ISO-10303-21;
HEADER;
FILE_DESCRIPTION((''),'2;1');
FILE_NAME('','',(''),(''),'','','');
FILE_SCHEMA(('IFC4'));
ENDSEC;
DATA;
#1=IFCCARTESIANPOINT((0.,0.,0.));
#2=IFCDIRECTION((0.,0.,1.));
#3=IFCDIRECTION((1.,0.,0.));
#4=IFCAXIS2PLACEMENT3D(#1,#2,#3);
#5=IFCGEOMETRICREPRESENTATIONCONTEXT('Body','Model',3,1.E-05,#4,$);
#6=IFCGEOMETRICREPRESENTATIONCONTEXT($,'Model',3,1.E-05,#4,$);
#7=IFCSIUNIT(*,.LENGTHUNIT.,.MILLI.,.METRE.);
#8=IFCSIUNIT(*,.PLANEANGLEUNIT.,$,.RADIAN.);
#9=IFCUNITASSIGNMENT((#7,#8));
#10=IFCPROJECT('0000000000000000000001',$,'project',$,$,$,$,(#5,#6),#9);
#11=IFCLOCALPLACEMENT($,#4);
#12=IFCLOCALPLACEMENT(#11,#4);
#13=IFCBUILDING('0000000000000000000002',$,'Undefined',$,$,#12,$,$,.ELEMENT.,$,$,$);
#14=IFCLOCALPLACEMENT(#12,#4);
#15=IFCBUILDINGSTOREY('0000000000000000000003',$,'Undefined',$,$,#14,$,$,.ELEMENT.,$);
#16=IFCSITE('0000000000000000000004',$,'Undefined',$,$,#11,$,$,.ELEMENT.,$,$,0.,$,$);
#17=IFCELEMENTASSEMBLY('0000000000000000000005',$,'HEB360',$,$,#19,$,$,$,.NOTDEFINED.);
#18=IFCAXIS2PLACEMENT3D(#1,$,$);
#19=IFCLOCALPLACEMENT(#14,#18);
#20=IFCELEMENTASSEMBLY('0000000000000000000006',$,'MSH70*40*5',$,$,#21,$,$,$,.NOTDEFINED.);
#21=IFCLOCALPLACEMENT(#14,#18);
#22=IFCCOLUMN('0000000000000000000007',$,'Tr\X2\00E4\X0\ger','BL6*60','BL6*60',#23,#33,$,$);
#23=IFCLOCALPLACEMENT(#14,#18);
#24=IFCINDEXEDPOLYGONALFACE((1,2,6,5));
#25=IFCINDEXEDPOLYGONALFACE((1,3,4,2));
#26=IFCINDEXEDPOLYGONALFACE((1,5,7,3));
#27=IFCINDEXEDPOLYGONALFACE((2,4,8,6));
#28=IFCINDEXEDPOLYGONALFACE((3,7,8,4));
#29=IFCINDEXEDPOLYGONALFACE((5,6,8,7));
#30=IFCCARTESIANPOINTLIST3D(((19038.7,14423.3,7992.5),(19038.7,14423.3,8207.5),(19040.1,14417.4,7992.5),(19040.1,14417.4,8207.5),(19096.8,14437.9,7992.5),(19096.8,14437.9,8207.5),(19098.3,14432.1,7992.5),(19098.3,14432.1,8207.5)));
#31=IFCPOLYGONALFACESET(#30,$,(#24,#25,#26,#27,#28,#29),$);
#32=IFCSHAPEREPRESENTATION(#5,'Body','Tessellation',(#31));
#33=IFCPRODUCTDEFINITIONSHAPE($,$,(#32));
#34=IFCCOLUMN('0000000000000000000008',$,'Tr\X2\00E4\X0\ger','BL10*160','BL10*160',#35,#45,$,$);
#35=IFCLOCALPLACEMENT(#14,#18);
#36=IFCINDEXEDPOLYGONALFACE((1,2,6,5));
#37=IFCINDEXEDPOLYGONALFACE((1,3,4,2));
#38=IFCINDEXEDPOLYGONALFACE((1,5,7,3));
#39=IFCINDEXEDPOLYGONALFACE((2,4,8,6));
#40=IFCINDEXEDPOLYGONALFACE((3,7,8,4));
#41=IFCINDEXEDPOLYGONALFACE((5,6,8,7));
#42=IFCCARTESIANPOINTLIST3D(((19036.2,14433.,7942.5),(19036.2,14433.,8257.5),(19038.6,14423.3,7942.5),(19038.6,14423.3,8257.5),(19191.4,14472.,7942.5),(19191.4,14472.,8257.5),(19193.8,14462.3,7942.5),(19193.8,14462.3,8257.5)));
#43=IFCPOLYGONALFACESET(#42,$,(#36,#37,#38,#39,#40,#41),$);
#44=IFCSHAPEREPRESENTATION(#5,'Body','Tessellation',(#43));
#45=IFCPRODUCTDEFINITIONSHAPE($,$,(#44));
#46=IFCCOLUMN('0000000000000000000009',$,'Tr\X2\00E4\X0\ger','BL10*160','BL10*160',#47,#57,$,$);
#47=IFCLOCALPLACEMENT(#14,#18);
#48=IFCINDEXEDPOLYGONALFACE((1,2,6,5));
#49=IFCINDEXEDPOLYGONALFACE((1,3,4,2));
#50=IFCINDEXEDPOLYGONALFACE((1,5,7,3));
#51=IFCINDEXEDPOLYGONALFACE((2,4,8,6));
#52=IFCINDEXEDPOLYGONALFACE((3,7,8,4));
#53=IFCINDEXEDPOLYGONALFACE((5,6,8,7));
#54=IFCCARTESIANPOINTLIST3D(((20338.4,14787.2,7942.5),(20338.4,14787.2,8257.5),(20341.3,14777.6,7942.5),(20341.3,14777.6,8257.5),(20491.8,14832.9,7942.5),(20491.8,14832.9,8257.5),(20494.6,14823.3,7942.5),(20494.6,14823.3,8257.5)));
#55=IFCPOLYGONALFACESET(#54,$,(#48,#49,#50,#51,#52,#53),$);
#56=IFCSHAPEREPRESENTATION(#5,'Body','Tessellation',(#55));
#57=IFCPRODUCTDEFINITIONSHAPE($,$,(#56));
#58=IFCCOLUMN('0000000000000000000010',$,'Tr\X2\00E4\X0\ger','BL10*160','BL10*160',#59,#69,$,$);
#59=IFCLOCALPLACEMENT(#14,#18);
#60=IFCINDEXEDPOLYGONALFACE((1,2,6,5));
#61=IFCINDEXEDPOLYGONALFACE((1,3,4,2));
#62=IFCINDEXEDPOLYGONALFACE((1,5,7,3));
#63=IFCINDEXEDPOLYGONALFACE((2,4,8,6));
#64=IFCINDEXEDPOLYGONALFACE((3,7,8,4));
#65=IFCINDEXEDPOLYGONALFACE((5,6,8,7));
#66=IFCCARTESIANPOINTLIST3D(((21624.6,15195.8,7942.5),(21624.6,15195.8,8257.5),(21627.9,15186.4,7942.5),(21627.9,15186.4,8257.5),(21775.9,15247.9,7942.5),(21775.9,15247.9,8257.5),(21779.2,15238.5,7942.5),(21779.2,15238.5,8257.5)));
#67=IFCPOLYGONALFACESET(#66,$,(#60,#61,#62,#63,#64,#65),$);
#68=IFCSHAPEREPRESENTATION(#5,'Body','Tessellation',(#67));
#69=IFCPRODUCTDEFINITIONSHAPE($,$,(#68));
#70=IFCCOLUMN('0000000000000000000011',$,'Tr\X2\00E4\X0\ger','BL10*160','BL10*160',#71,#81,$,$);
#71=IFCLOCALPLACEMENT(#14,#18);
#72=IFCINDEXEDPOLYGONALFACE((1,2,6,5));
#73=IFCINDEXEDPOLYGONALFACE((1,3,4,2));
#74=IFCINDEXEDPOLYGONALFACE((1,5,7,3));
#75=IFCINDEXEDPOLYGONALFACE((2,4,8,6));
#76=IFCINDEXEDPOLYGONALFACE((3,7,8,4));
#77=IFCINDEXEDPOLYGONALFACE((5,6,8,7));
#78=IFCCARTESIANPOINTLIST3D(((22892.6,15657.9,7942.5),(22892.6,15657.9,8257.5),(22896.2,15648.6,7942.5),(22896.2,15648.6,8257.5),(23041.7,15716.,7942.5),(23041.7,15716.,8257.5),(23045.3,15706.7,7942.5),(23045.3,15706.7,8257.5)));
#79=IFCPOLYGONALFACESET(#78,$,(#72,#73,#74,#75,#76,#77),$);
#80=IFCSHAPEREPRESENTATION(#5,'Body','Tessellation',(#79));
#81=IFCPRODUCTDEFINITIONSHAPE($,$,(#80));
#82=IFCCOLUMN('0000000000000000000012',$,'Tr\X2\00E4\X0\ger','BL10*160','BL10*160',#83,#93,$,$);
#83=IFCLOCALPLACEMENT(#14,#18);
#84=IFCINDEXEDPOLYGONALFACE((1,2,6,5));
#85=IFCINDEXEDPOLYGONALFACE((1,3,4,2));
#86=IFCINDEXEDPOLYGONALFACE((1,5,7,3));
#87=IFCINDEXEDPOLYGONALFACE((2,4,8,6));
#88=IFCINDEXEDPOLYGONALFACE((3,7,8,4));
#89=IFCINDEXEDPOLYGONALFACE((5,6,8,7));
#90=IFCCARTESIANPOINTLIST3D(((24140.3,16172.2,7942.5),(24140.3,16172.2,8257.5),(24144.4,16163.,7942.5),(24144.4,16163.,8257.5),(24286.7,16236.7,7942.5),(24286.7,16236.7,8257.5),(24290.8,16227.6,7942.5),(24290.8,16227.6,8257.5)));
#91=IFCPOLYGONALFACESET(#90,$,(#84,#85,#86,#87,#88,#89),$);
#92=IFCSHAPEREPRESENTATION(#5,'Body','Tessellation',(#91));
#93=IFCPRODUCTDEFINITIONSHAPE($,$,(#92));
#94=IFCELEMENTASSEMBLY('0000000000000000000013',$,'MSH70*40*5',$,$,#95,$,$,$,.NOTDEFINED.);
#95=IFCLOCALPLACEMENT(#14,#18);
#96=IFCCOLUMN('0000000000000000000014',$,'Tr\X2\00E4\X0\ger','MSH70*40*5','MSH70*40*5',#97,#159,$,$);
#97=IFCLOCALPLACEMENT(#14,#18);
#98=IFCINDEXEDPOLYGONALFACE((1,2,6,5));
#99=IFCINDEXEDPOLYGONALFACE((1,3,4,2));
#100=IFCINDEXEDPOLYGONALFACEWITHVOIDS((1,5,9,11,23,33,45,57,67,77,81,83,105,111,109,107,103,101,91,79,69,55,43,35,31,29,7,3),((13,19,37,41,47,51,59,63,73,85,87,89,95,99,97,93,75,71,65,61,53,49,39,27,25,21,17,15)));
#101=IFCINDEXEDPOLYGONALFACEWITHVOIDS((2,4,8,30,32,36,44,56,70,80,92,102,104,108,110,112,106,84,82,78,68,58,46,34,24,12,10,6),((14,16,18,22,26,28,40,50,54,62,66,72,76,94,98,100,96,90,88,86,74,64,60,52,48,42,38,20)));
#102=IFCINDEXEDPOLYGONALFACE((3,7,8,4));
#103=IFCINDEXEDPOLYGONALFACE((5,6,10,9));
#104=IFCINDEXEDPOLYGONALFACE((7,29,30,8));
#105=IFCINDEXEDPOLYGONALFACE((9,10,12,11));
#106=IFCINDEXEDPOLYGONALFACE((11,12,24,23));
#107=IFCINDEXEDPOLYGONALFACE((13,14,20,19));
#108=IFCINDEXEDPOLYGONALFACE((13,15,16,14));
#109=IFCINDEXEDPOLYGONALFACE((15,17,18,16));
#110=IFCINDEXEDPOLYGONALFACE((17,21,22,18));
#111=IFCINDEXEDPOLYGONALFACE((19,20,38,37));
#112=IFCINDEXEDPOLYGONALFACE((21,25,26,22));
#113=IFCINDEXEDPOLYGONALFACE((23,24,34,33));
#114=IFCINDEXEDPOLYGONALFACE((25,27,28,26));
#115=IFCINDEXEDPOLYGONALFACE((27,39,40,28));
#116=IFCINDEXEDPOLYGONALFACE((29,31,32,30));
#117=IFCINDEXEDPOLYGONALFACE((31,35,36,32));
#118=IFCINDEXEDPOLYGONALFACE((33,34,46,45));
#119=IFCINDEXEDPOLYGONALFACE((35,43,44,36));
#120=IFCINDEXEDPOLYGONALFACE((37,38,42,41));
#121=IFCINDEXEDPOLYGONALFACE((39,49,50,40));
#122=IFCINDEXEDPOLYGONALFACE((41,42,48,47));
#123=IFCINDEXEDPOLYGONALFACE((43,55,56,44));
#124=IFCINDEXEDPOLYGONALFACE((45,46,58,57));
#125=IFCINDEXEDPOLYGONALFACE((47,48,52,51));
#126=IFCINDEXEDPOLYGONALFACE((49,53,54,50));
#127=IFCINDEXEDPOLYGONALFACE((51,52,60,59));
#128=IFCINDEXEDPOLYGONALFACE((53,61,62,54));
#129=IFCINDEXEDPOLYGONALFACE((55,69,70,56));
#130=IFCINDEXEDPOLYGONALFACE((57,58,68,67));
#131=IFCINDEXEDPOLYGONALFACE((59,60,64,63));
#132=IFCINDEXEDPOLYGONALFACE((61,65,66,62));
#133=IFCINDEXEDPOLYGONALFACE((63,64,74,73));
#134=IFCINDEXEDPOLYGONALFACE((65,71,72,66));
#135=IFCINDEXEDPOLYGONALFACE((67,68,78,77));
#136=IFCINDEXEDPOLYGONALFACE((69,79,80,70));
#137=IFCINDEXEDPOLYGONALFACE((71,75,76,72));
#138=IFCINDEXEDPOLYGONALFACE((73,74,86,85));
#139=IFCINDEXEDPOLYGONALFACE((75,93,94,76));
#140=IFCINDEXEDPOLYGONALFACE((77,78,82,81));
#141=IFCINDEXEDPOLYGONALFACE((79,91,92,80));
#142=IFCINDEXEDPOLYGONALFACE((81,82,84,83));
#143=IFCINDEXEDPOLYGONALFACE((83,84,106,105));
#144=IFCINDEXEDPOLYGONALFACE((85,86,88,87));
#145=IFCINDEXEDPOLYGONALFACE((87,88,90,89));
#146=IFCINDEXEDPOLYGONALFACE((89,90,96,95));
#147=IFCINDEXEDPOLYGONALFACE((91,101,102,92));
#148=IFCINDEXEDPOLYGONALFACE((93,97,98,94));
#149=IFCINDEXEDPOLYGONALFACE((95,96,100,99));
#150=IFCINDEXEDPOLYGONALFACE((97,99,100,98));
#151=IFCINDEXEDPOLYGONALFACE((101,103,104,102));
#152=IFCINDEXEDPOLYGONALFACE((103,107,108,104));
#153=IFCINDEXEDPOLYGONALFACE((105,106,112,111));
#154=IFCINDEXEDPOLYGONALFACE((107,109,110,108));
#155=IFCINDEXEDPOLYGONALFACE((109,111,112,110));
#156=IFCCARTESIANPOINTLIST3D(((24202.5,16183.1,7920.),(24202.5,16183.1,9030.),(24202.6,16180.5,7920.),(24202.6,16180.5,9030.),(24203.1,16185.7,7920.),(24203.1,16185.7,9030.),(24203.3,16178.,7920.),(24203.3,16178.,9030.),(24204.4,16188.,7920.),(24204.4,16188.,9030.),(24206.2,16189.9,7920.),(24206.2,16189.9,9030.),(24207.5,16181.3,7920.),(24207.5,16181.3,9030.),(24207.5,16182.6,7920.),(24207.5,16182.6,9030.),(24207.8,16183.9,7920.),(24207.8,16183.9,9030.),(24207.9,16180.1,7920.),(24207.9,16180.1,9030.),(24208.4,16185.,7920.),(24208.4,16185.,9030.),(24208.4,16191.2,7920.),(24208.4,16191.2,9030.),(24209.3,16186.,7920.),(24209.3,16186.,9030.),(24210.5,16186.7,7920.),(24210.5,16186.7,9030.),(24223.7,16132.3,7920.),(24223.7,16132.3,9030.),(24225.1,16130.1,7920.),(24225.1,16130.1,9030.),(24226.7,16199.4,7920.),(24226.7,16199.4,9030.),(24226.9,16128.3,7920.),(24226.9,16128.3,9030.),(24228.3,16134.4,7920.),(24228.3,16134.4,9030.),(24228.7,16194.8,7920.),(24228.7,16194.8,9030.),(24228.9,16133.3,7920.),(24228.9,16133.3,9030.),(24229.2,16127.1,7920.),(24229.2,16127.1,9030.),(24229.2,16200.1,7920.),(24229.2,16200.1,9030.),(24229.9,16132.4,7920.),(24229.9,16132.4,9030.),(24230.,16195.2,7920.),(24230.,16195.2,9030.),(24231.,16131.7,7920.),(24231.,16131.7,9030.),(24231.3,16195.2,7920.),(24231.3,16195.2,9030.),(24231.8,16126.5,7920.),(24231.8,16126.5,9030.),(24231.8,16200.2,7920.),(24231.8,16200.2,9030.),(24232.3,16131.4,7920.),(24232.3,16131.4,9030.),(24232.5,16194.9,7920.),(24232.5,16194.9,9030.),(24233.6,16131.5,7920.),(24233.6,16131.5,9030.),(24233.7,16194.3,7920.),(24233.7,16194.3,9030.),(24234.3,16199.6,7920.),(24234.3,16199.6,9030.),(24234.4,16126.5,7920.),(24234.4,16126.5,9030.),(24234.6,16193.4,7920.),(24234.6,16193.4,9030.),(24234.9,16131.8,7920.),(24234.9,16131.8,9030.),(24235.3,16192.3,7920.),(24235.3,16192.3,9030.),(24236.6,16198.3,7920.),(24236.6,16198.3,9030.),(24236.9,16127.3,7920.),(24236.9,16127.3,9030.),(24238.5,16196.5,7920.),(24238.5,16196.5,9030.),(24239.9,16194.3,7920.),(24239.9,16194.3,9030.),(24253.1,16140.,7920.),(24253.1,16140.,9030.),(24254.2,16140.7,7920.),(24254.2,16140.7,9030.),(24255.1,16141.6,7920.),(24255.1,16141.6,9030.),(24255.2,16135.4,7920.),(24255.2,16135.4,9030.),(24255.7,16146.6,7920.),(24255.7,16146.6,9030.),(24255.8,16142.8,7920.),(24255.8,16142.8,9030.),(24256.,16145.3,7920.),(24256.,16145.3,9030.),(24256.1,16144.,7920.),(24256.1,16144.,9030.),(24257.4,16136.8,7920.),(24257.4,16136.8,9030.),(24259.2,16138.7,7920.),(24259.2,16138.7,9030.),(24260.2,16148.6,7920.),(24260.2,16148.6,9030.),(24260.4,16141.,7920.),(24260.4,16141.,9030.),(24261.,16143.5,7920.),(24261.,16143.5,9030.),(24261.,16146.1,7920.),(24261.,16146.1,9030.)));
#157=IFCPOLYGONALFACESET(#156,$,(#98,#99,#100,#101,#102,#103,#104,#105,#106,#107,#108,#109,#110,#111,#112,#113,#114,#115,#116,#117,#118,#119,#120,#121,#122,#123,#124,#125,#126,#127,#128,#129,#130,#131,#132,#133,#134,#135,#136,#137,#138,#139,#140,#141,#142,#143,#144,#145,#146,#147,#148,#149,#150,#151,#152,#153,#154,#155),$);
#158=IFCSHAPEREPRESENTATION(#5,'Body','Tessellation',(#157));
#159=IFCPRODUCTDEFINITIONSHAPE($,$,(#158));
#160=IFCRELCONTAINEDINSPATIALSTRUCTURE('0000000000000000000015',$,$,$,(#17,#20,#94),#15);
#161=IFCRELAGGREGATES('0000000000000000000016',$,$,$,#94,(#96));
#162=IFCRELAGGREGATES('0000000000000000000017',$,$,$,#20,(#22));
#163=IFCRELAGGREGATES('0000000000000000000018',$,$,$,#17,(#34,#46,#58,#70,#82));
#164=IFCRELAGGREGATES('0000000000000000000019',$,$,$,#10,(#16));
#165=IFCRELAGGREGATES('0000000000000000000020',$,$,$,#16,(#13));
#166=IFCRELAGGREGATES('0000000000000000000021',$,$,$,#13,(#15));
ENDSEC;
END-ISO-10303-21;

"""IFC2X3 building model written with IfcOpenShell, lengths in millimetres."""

from ifc_helpers import new_model, si_unit, frame, origin_with_axes, origin_2d_with_axis, place, context, project, spatial, rectangle, hollow_rectangle, extrude, element, aggregate, save


model = new_model("IFC2X3")

# Units and contexts
model_context_1 = context("Model", 3, precision=1e-05, world=origin_with_axes(), identifier="Body")
model_context_2 = context("Model", 3, precision=1e-05, world=origin_with_axes())
ifc_project = project(units=[si_unit("LENGTHUNIT", "METRE", prefix="MILLI"), si_unit("PLANEANGLEUNIT", "RADIAN")], contexts=[model_context_1, model_context_2])

# Site, building, storey
site_placement = place(None, origin_with_axes())
site = spatial("IfcSite", under=ifc_project, at=site_placement, Name="Undefined", CompositionType="ELEMENT", RefElevation=0.0)
building_placement = place(site_placement, origin_with_axes())
building = spatial("IfcBuilding", under=site, at=building_placement, Name="Undefined", CompositionType="ELEMENT")
storey_placement = place(building_placement, origin_with_axes())
storey = spatial("IfcBuildingStorey", under=building, at=storey_placement, Name="Undefined", CompositionType="ELEMENT")

# Element assemblies, column
assembly_1 = element("IfcElementAssembly", 1, inside=storey, Name="HEB360", PredefinedType="NOTDEFINED")
assembly_2 = element("IfcElementAssembly", 2, inside=storey, Name="MSH70*40*5", PredefinedType="NOTDEFINED")
column_1_placement = place(storey_placement, frame((19068.5, 14427.7, 7992.5), z_axis=(0.0, 0.0, 1.0), x_axis=(1.0, 0.0, 0.0)))
column_1 = element("IfcColumn", 3, at=column_1_placement, Name="Träger", Description="BL6*60", ObjectType="BL6*60", context=model_context_1, shape_type="SweptSolid", body=[
    extrude(rectangle(XDim=6.0, YDim=60.0, at=origin_2d_with_axis()), frame((0.0, 0.0, 215.0), z_axis=(0.0, 0.0, -1.0), x_axis=(0.243615, -0.969872, 0.0)), (0.0, 0.0, 1.0), 215.0),
])

# Columns
column_2_placement = place(storey_placement, frame((19115.0, 14447.7, 7942.5), z_axis=(0.0, 0.0, 1.0), x_axis=(1.0, 0.0, 0.0)))
column_2 = element("IfcColumn", 4, at=column_2_placement, Name="Träger", Description="BL10*160", ObjectType="BL10*160", context=model_context_1, shape_type="SweptSolid", body=[
    extrude(rectangle(XDim=10.0, YDim=160.0, at=origin_2d_with_axis()), frame((0.0, 0.0, 315.0), z_axis=(0.0, 0.0, -1.0), x_axis=(0.243615, -0.969872, 0.0)), (0.0, 0.0, 1.0), 315.0),
])
column_3_placement = place(storey_placement, frame((20416.5, 14805.3, 7942.5), z_axis=(0.0, 0.0, 1.0), x_axis=(1.0, 0.0, 0.0)))
column_3 = element("IfcColumn", 5, at=column_3_placement, Name="Träger", Description="BL10*160", ObjectType="BL10*160", context=model_context_1, shape_type="SweptSolid", body=[
    extrude(rectangle(XDim=10.0, YDim=160.0, at=origin_2d_with_axis()), frame((0.0, 0.0, 315.0), z_axis=(0.0, 0.0, -1.0), x_axis=(0.285688, -0.958323, 0.0)), (0.0, 0.0, 1.0), 315.0),
])
column_4_placement = place(storey_placement, frame((21701.9, 15217.2, 7942.5), z_axis=(0.0, 0.0, 1.0), x_axis=(1.0, 0.0, 0.0)))
column_4 = element("IfcColumn", 6, at=column_4_placement, Name="Träger", Description="BL10*160", ObjectType="BL10*160", context=model_context_1, shape_type="SweptSolid", body=[
    extrude(rectangle(XDim=10.0, YDim=160.0, at=origin_2d_with_axis()), frame((0.0, 0.0, 315.0), z_axis=(0.0, 0.0, -1.0), x_axis=(0.325568, -0.945519, 0.0)), (0.0, 0.0, 1.0), 315.0),
])
column_5_placement = place(storey_placement, frame((22969.0, 15682.3, 7942.5), z_axis=(0.0, 0.0, 1.0), x_axis=(1.0, 0.0, 0.0)))
column_5 = element("IfcColumn", 7, at=column_5_placement, Name="Träger", Description="BL10*160", ObjectType="BL10*160", context=model_context_1, shape_type="SweptSolid", body=[
    extrude(rectangle(XDim=10.0, YDim=160.0, at=origin_2d_with_axis()), frame((0.0, 0.0, 315.0), z_axis=(0.0, 0.0, -1.0), x_axis=(0.363251, -0.931691, 0.0)), (0.0, 0.0, 1.0), 315.0),
])
column_6_placement = place(storey_placement, frame((24215.5, 16199.9, 7942.5), z_axis=(0.0, 0.0, 1.0), x_axis=(1.0, 0.0, 0.0)))
column_6 = element("IfcColumn", 8, at=column_6_placement, Name="Träger", Description="BL10*160", ObjectType="BL10*160", context=model_context_1, shape_type="SweptSolid", body=[
    extrude(rectangle(XDim=10.0, YDim=160.0, at=origin_2d_with_axis()), frame((0.0, 0.0, 315.0), z_axis=(0.0, 0.0, -1.0), x_axis=(0.403545, -0.91496, 0.0)), (0.0, 0.0, 1.0), 315.0),
])

# Element assembly, column
assembly_3 = element("IfcElementAssembly", 9, inside=storey, Name="MSH70*40*5", PredefinedType="NOTDEFINED")
column_7_placement = place(storey_placement, frame((24231.8, 16163.3, 7920.0), z_axis=(0.0, 0.0, 1.0), x_axis=(1.0, 0.0, 0.0)))
column_7 = element("IfcColumn", 10, at=column_7_placement, Name="Träger", Description="MSH70*40*5", ObjectType="MSH70*40*5", context=model_context_1, shape_type="SweptSolid", body=[
    extrude(hollow_rectangle(XDim=40.0, YDim=70.0, WallThickness=5.0, InnerFilletRadius=5.0, OuterFilletRadius=10.0, at=origin_2d_with_axis()), frame((0.0, 0.0, 1110.0), z_axis=(0.0, 0.0, -1.0), x_axis=(-0.913545, -0.406737, 0.000005)), (0.0, 0.0, 1.0), 1110.0),
])
aggregate(assembly_3, [column_7])

aggregate(assembly_2, [column_1])
aggregate(assembly_1, [column_2, column_3, column_4, column_5, column_6])

save(model, "model.ifc")
